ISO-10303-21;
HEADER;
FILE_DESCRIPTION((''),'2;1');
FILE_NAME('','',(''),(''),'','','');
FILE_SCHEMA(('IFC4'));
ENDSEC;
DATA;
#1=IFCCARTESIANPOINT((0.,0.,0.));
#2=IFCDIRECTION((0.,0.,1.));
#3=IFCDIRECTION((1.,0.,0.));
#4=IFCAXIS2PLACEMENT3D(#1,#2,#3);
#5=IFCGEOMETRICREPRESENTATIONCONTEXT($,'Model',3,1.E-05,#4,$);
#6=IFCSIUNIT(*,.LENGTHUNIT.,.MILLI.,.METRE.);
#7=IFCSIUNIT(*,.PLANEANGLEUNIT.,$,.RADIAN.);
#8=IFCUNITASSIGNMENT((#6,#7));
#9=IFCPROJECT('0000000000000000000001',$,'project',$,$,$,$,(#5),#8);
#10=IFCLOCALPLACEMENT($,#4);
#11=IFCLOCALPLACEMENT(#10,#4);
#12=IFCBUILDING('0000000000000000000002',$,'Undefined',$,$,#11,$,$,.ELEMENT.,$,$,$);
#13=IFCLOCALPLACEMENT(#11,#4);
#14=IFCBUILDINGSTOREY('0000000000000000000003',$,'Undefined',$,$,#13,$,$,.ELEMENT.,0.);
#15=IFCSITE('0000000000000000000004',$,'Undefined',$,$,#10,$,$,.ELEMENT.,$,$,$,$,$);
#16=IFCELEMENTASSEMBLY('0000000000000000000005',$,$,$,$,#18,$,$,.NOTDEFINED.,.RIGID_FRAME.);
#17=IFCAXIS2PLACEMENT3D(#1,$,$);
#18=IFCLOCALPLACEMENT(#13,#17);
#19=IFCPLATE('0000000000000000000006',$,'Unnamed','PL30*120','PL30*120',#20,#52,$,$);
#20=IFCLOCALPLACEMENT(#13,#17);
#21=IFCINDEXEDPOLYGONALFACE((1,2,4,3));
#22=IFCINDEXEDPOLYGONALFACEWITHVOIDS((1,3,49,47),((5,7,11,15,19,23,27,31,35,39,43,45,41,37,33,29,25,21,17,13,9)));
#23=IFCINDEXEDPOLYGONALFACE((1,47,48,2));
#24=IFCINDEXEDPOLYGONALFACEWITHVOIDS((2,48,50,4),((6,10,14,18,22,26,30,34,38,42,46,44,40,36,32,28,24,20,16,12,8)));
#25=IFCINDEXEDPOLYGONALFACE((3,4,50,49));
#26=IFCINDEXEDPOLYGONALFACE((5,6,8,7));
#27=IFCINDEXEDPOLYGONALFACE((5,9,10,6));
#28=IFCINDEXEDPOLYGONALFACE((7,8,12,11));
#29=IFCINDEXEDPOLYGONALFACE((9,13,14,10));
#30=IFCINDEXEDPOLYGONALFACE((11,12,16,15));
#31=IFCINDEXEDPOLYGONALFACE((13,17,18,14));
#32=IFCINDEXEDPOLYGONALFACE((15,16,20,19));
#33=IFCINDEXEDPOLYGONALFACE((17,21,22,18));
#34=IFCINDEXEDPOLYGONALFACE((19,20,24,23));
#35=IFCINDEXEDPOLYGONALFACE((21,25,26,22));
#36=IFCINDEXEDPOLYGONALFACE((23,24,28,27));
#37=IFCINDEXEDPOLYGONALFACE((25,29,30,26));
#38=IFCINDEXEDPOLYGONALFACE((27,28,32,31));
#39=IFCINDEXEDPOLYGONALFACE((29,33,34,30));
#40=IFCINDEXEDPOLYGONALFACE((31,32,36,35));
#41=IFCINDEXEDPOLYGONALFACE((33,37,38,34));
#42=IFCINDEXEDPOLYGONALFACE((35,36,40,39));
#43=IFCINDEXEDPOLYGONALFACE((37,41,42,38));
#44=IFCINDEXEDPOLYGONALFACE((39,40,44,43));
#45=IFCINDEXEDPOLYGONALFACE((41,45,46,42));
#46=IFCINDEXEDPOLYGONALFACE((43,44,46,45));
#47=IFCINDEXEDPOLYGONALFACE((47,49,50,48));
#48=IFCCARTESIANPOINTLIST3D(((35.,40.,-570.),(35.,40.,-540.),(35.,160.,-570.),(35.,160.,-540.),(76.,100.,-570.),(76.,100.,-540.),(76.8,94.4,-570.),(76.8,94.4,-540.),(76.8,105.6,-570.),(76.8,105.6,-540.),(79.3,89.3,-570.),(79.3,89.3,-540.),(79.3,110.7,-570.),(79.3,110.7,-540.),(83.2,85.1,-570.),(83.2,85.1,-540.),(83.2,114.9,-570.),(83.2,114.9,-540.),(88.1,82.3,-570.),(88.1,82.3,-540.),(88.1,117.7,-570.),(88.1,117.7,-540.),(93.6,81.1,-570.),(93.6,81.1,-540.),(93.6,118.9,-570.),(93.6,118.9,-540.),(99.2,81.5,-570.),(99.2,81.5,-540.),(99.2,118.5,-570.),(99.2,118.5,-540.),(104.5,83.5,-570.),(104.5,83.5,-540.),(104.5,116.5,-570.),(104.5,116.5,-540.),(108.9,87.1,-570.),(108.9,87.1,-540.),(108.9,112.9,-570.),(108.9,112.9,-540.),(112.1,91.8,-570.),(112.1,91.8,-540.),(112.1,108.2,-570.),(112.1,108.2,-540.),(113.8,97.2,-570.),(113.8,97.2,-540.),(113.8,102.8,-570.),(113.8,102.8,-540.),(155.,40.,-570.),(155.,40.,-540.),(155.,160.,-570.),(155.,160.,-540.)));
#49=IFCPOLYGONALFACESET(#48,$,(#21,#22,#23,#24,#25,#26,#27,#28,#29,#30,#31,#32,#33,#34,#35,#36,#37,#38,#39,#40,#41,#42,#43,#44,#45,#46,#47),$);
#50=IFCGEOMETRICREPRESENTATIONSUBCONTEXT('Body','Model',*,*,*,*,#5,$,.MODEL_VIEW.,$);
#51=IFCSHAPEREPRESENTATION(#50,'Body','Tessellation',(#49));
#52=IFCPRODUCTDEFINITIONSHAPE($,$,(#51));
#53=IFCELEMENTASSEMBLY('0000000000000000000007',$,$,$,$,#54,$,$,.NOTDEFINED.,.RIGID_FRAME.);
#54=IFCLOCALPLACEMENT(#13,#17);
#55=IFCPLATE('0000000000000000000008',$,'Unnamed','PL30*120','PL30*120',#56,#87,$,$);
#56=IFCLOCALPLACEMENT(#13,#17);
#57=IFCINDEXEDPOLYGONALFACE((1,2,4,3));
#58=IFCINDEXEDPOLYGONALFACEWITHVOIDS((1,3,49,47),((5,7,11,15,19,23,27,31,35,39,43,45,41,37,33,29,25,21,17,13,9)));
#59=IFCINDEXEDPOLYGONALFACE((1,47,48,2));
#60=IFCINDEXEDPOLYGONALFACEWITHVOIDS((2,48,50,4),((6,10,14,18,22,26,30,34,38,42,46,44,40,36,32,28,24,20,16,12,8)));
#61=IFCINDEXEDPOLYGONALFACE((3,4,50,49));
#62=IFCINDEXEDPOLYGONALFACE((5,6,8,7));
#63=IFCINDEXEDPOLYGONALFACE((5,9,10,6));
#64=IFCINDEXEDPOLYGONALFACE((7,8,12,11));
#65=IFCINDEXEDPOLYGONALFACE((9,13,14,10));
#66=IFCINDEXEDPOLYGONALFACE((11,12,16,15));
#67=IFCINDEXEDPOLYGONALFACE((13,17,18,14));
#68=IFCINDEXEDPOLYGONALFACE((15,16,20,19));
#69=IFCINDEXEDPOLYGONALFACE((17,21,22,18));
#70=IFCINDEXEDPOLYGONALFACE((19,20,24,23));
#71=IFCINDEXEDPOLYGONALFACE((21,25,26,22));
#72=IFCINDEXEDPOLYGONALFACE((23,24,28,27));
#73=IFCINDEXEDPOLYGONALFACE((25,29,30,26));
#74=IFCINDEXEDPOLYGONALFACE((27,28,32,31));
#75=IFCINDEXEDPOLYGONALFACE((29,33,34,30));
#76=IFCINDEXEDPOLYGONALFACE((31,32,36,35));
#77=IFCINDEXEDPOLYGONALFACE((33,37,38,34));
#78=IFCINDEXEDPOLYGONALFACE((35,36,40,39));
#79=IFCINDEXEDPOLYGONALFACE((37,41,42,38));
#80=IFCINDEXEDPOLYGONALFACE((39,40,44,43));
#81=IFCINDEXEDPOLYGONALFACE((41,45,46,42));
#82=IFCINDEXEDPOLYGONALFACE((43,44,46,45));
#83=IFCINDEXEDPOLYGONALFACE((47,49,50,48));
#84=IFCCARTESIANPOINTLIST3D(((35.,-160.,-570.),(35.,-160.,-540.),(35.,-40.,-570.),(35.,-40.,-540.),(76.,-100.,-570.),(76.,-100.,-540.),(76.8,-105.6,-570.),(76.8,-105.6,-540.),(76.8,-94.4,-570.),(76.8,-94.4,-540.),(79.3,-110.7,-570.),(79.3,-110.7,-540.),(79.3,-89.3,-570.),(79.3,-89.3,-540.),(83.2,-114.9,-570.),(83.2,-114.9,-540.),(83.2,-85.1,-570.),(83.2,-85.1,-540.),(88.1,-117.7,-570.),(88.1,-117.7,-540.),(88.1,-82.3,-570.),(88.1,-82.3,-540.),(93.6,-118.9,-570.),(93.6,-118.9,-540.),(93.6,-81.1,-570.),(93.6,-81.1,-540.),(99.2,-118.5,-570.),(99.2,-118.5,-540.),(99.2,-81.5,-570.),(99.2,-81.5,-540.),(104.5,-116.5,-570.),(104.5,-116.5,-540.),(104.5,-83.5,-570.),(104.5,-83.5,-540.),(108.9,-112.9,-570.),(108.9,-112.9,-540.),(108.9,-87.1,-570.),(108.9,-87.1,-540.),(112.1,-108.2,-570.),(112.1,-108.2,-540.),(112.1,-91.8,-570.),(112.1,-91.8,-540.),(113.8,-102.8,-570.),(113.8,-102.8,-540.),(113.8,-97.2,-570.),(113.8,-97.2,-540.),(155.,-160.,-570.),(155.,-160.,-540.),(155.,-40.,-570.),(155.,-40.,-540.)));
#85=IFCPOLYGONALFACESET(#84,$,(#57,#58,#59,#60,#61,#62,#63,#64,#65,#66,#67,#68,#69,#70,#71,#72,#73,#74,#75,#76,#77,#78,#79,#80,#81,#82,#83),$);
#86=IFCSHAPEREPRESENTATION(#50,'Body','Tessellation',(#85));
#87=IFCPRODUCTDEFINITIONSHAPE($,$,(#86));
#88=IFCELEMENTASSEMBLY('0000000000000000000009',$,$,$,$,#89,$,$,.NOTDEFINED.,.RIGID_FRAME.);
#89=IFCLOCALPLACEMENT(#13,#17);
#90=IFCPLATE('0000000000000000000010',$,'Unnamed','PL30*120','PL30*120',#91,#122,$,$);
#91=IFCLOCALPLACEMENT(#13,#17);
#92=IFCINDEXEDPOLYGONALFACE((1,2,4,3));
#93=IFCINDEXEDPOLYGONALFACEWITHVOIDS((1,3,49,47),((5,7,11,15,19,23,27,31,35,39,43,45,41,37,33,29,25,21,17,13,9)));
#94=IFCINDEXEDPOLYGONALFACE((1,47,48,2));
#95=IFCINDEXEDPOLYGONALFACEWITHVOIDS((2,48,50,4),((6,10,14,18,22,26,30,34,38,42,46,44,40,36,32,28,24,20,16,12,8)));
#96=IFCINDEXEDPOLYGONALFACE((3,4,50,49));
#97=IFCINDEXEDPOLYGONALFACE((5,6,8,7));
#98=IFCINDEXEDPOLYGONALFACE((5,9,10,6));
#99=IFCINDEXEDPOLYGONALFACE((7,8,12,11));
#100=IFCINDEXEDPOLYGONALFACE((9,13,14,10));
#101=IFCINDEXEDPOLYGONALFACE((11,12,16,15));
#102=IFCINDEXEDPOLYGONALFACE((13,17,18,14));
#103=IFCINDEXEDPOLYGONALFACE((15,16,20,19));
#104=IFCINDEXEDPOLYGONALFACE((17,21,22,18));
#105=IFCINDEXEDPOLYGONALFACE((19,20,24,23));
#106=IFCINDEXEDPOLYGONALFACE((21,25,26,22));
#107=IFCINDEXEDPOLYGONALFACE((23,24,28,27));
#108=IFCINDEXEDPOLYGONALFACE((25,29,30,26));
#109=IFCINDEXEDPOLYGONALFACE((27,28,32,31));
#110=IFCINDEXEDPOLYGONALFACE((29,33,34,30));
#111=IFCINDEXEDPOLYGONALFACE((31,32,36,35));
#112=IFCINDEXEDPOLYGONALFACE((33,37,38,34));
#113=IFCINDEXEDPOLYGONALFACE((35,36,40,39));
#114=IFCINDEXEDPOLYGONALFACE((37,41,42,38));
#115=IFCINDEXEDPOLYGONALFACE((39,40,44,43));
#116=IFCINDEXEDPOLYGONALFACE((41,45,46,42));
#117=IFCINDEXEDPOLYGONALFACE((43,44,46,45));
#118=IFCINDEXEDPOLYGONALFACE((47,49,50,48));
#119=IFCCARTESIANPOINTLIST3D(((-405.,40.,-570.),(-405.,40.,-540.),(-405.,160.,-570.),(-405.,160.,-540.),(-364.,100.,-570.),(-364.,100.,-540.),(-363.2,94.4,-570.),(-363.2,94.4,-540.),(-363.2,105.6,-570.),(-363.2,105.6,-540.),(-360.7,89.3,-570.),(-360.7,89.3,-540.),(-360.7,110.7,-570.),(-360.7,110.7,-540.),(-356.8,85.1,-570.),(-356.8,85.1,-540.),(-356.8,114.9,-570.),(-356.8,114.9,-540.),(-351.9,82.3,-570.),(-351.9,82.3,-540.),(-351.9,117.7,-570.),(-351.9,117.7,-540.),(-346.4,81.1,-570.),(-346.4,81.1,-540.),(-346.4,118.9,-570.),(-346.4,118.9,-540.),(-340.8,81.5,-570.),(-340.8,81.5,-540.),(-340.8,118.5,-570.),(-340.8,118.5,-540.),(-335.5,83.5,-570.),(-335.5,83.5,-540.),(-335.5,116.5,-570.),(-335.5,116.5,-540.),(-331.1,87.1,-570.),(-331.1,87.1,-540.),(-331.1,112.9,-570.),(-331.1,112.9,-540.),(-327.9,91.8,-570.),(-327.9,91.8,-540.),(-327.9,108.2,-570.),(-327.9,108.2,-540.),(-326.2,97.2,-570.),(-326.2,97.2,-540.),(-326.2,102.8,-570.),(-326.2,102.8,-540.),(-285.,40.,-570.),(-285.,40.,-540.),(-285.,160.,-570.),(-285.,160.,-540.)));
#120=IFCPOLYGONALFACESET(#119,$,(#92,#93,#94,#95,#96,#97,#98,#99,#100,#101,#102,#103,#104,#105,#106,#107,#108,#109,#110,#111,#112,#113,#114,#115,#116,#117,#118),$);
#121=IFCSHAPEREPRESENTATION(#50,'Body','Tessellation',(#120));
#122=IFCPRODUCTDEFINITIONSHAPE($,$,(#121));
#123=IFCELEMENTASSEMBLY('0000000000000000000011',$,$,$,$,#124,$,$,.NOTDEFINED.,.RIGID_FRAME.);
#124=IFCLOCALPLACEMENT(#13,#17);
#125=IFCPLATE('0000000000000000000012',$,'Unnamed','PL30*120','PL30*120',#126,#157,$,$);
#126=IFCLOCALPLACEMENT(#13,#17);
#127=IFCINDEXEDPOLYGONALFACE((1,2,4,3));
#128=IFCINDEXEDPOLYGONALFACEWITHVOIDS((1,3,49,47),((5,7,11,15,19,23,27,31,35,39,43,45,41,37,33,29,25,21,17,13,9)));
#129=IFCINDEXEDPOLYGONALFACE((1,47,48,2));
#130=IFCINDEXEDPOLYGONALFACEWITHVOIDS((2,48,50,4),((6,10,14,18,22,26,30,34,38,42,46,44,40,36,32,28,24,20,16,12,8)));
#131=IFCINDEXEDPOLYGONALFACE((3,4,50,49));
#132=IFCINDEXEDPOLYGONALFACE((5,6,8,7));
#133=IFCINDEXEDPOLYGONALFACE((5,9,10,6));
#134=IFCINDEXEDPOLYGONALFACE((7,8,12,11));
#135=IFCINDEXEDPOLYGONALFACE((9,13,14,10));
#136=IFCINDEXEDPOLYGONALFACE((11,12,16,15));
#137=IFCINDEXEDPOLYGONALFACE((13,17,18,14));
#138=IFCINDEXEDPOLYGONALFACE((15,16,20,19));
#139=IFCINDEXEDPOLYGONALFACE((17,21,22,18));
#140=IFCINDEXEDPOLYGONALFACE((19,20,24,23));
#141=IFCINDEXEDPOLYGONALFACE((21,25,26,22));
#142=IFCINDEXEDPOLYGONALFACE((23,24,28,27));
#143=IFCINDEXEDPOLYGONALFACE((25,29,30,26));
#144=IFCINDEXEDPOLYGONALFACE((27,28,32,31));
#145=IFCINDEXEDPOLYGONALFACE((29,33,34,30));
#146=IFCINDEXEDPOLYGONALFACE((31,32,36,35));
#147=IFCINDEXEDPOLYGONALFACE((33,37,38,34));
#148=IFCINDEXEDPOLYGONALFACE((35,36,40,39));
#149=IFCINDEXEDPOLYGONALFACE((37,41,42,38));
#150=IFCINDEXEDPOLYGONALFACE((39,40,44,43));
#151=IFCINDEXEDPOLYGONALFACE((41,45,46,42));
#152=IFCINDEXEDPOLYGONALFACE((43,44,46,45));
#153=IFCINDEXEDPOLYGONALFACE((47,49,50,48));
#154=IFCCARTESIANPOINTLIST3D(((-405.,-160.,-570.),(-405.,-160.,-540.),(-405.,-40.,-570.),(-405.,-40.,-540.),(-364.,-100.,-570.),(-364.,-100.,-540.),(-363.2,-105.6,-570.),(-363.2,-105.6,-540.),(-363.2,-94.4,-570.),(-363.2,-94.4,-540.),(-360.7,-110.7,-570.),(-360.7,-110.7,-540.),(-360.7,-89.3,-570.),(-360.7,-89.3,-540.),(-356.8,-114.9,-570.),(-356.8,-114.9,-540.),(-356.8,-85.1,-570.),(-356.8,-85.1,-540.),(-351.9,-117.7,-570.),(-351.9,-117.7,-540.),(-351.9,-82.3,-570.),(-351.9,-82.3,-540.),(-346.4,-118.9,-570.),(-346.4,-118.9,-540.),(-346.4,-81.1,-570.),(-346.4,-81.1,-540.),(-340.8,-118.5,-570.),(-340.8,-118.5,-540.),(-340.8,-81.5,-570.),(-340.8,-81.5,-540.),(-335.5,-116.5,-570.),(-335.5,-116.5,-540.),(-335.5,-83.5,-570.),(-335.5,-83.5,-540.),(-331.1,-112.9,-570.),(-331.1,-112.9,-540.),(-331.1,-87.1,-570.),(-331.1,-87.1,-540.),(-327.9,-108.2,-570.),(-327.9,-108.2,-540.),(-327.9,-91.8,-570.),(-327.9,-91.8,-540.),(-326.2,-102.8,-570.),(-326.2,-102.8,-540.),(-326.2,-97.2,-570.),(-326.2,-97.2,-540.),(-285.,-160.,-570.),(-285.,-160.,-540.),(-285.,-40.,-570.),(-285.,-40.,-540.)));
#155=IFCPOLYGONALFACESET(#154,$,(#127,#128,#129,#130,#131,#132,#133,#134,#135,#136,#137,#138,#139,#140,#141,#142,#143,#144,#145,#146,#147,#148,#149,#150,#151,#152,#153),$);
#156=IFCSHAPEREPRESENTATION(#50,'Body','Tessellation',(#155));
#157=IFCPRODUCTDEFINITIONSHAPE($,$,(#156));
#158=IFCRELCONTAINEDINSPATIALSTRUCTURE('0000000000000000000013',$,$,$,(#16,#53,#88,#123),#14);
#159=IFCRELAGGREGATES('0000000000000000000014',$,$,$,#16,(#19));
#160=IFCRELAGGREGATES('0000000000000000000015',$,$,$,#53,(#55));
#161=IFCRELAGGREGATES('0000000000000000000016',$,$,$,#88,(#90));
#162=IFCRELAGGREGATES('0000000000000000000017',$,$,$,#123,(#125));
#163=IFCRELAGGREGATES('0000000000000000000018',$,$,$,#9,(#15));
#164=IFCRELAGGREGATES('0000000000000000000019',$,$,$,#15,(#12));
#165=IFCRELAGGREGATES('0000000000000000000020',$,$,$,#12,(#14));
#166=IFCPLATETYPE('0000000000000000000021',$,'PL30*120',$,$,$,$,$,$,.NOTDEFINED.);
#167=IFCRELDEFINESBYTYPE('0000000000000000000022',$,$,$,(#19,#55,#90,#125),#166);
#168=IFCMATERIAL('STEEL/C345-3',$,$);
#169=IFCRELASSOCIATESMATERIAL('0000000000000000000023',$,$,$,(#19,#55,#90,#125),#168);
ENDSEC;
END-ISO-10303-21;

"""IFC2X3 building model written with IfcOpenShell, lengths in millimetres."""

from ifc_helpers import new_model, si_unit, frame, origin_with_axes, origin_2d_with_axis, place, context, subcontext, project, spatial, polyline, circle, outline, extrude, boolean, material, type_object, element, aggregate, save


model = new_model("IFC2X3")

# Units and contexts
model_context = context("Model", 3, precision=1e-05, world=origin_with_axes())
body_context = subcontext(model_context, "Body", "Model", "MODEL_VIEW")
ifc_project = project(units=[si_unit("LENGTHUNIT", "METRE", prefix="MILLI"), si_unit("PLANEANGLEUNIT", "RADIAN")], contexts=[model_context])

# Site, building, storey
site_placement = place(None, origin_with_axes())
site = spatial("IfcSite", under=ifc_project, at=site_placement, Name="Undefined", CompositionType="ELEMENT")
building_placement = place(site_placement, origin_with_axes())
building = spatial("IfcBuilding", under=site, at=building_placement, Name="Undefined", CompositionType="ELEMENT")
storey_placement = place(building_placement, origin_with_axes())
storey = spatial("IfcBuildingStorey", under=building, at=storey_placement, Name="Undefined", CompositionType="ELEMENT", Elevation=0.0)

# Shared definitions
ifc_material_1 = material(Name="STEEL/C345-3")

# Element assemblies, plates
assembly_1_placement = place(storey_placement, origin_with_axes())
assembly_1 = element("IfcElementAssembly", 1, at=assembly_1_placement, inside=storey, AssemblyPlace="NOTDEFINED", PredefinedType="RIGID_FRAME")
plate_type_1 = type_object("IfcPlateType", Name="PL30*120", PredefinedType="NOTDEFINED")
plate_1_placement = place(assembly_1_placement, frame((155.0, 40.0, -555.0), z_axis=(0.0, 0.0, 1.0), x_axis=(0.0, 1.0, 0.0)))
plate_1 = element("IfcPlate", 2, at=plate_1_placement, type_object=plate_type_1, material=ifc_material_1, Name="Unnamed", Description="PL30*120", ObjectType="PL30*120", context=body_context, shape_type="CSG", body=[
    boolean("DIFFERENCE", extrude(outline(polyline([(0.0, 0.0), (120.0, 0.0), (120.0, 120.0), (0.0, 120.0), (0.0, 0.0)])), frame((0.0, 0.0, -15.0), z_axis=(0.0, 0.0, 1.0), x_axis=(1.0, 0.0, 0.0)), (0.0, 0.0, 1.0), 30.0), extrude(circle(Radius=19.0, at=origin_2d_with_axis()), frame((60.0, 60.0, 45.0), z_axis=(0.0, 0.0, -1.0), x_axis=(0.0, 1.0, 0.0)), (0.0, 0.0, 1.0), 80.0)),
])
aggregate(assembly_1, [plate_1])
assembly_2_placement = place(storey_placement, origin_with_axes())
assembly_2 = element("IfcElementAssembly", 3, at=assembly_2_placement, inside=storey, AssemblyPlace="NOTDEFINED", PredefinedType="RIGID_FRAME")
plate_2_placement = place(assembly_2_placement, frame((155.0, -160.0, -555.0), z_axis=(0.0, 0.0, 1.0), x_axis=(0.0, 1.0, 0.0)))
plate_2 = element("IfcPlate", 4, at=plate_2_placement, type_object=plate_type_1, material=ifc_material_1, Name="Unnamed", Description="PL30*120", ObjectType="PL30*120", context=body_context, shape_type="CSG", body=[
    boolean("DIFFERENCE", extrude(outline(polyline([(0.0, 0.0), (120.0, 0.0), (120.0, 120.0), (0.0, 120.0), (0.0, 0.0)])), frame((0.0, 0.0, -15.0), z_axis=(0.0, 0.0, 1.0), x_axis=(1.0, 0.0, 0.0)), (0.0, 0.0, 1.0), 30.0), extrude(circle(Radius=19.0, at=origin_2d_with_axis()), frame((60.0, 60.0, 45.0), z_axis=(0.0, 0.0, -1.0), x_axis=(0.0, 1.0, 0.0)), (0.0, 0.0, 1.0), 80.0)),
])
aggregate(assembly_2, [plate_2])
assembly_3_placement = place(storey_placement, origin_with_axes())
assembly_3 = element("IfcElementAssembly", 5, at=assembly_3_placement, inside=storey, AssemblyPlace="NOTDEFINED", PredefinedType="RIGID_FRAME")
plate_3_placement = place(assembly_3_placement, frame((-285.0, 40.0, -555.0), z_axis=(0.0, 0.0, 1.0), x_axis=(0.0, 1.0, 0.0)))
plate_3 = element("IfcPlate", 6, at=plate_3_placement, type_object=plate_type_1, material=ifc_material_1, Name="Unnamed", Description="PL30*120", ObjectType="PL30*120", context=body_context, shape_type="CSG", body=[
    boolean("DIFFERENCE", extrude(outline(polyline([(0.0, 0.0), (120.0, 0.0), (120.0, 120.0), (0.0, 120.0), (0.0, 0.0)])), frame((0.0, 0.0, -15.0), z_axis=(0.0, 0.0, 1.0), x_axis=(1.0, 0.0, 0.0)), (0.0, 0.0, 1.0), 30.0), extrude(circle(Radius=19.0, at=origin_2d_with_axis()), frame((60.0, 60.0, 45.0), z_axis=(0.0, 0.0, -1.0), x_axis=(0.0, 1.0, 0.0)), (0.0, 0.0, 1.0), 80.0)),
])
aggregate(assembly_3, [plate_3])
assembly_4_placement = place(storey_placement, origin_with_axes())
assembly_4 = element("IfcElementAssembly", 7, at=assembly_4_placement, inside=storey, AssemblyPlace="NOTDEFINED", PredefinedType="RIGID_FRAME")
plate_4_placement = place(assembly_4_placement, frame((-285.0, -160.0, -555.0), z_axis=(0.0, 0.0, 1.0), x_axis=(0.0, 1.0, 0.0)))
plate_4 = element("IfcPlate", 8, at=plate_4_placement, type_object=plate_type_1, material=ifc_material_1, Name="Unnamed", Description="PL30*120", ObjectType="PL30*120", context=body_context, shape_type="CSG", body=[
    boolean("DIFFERENCE", extrude(outline(polyline([(0.0, 0.0), (120.0, 0.0), (120.0, 120.0), (0.0, 120.0), (0.0, 0.0)])), frame((0.0, 0.0, -15.0), z_axis=(0.0, 0.0, 1.0), x_axis=(1.0, 0.0, 0.0)), (0.0, 0.0, 1.0), 30.0), extrude(circle(Radius=19.0, at=origin_2d_with_axis()), frame((60.0, 60.0, 45.0), z_axis=(0.0, 0.0, -1.0), x_axis=(0.0, 1.0, 0.0)), (0.0, 0.0, 1.0), 80.0)),
])
aggregate(assembly_4, [plate_4])

save(model, "model.ifc")
